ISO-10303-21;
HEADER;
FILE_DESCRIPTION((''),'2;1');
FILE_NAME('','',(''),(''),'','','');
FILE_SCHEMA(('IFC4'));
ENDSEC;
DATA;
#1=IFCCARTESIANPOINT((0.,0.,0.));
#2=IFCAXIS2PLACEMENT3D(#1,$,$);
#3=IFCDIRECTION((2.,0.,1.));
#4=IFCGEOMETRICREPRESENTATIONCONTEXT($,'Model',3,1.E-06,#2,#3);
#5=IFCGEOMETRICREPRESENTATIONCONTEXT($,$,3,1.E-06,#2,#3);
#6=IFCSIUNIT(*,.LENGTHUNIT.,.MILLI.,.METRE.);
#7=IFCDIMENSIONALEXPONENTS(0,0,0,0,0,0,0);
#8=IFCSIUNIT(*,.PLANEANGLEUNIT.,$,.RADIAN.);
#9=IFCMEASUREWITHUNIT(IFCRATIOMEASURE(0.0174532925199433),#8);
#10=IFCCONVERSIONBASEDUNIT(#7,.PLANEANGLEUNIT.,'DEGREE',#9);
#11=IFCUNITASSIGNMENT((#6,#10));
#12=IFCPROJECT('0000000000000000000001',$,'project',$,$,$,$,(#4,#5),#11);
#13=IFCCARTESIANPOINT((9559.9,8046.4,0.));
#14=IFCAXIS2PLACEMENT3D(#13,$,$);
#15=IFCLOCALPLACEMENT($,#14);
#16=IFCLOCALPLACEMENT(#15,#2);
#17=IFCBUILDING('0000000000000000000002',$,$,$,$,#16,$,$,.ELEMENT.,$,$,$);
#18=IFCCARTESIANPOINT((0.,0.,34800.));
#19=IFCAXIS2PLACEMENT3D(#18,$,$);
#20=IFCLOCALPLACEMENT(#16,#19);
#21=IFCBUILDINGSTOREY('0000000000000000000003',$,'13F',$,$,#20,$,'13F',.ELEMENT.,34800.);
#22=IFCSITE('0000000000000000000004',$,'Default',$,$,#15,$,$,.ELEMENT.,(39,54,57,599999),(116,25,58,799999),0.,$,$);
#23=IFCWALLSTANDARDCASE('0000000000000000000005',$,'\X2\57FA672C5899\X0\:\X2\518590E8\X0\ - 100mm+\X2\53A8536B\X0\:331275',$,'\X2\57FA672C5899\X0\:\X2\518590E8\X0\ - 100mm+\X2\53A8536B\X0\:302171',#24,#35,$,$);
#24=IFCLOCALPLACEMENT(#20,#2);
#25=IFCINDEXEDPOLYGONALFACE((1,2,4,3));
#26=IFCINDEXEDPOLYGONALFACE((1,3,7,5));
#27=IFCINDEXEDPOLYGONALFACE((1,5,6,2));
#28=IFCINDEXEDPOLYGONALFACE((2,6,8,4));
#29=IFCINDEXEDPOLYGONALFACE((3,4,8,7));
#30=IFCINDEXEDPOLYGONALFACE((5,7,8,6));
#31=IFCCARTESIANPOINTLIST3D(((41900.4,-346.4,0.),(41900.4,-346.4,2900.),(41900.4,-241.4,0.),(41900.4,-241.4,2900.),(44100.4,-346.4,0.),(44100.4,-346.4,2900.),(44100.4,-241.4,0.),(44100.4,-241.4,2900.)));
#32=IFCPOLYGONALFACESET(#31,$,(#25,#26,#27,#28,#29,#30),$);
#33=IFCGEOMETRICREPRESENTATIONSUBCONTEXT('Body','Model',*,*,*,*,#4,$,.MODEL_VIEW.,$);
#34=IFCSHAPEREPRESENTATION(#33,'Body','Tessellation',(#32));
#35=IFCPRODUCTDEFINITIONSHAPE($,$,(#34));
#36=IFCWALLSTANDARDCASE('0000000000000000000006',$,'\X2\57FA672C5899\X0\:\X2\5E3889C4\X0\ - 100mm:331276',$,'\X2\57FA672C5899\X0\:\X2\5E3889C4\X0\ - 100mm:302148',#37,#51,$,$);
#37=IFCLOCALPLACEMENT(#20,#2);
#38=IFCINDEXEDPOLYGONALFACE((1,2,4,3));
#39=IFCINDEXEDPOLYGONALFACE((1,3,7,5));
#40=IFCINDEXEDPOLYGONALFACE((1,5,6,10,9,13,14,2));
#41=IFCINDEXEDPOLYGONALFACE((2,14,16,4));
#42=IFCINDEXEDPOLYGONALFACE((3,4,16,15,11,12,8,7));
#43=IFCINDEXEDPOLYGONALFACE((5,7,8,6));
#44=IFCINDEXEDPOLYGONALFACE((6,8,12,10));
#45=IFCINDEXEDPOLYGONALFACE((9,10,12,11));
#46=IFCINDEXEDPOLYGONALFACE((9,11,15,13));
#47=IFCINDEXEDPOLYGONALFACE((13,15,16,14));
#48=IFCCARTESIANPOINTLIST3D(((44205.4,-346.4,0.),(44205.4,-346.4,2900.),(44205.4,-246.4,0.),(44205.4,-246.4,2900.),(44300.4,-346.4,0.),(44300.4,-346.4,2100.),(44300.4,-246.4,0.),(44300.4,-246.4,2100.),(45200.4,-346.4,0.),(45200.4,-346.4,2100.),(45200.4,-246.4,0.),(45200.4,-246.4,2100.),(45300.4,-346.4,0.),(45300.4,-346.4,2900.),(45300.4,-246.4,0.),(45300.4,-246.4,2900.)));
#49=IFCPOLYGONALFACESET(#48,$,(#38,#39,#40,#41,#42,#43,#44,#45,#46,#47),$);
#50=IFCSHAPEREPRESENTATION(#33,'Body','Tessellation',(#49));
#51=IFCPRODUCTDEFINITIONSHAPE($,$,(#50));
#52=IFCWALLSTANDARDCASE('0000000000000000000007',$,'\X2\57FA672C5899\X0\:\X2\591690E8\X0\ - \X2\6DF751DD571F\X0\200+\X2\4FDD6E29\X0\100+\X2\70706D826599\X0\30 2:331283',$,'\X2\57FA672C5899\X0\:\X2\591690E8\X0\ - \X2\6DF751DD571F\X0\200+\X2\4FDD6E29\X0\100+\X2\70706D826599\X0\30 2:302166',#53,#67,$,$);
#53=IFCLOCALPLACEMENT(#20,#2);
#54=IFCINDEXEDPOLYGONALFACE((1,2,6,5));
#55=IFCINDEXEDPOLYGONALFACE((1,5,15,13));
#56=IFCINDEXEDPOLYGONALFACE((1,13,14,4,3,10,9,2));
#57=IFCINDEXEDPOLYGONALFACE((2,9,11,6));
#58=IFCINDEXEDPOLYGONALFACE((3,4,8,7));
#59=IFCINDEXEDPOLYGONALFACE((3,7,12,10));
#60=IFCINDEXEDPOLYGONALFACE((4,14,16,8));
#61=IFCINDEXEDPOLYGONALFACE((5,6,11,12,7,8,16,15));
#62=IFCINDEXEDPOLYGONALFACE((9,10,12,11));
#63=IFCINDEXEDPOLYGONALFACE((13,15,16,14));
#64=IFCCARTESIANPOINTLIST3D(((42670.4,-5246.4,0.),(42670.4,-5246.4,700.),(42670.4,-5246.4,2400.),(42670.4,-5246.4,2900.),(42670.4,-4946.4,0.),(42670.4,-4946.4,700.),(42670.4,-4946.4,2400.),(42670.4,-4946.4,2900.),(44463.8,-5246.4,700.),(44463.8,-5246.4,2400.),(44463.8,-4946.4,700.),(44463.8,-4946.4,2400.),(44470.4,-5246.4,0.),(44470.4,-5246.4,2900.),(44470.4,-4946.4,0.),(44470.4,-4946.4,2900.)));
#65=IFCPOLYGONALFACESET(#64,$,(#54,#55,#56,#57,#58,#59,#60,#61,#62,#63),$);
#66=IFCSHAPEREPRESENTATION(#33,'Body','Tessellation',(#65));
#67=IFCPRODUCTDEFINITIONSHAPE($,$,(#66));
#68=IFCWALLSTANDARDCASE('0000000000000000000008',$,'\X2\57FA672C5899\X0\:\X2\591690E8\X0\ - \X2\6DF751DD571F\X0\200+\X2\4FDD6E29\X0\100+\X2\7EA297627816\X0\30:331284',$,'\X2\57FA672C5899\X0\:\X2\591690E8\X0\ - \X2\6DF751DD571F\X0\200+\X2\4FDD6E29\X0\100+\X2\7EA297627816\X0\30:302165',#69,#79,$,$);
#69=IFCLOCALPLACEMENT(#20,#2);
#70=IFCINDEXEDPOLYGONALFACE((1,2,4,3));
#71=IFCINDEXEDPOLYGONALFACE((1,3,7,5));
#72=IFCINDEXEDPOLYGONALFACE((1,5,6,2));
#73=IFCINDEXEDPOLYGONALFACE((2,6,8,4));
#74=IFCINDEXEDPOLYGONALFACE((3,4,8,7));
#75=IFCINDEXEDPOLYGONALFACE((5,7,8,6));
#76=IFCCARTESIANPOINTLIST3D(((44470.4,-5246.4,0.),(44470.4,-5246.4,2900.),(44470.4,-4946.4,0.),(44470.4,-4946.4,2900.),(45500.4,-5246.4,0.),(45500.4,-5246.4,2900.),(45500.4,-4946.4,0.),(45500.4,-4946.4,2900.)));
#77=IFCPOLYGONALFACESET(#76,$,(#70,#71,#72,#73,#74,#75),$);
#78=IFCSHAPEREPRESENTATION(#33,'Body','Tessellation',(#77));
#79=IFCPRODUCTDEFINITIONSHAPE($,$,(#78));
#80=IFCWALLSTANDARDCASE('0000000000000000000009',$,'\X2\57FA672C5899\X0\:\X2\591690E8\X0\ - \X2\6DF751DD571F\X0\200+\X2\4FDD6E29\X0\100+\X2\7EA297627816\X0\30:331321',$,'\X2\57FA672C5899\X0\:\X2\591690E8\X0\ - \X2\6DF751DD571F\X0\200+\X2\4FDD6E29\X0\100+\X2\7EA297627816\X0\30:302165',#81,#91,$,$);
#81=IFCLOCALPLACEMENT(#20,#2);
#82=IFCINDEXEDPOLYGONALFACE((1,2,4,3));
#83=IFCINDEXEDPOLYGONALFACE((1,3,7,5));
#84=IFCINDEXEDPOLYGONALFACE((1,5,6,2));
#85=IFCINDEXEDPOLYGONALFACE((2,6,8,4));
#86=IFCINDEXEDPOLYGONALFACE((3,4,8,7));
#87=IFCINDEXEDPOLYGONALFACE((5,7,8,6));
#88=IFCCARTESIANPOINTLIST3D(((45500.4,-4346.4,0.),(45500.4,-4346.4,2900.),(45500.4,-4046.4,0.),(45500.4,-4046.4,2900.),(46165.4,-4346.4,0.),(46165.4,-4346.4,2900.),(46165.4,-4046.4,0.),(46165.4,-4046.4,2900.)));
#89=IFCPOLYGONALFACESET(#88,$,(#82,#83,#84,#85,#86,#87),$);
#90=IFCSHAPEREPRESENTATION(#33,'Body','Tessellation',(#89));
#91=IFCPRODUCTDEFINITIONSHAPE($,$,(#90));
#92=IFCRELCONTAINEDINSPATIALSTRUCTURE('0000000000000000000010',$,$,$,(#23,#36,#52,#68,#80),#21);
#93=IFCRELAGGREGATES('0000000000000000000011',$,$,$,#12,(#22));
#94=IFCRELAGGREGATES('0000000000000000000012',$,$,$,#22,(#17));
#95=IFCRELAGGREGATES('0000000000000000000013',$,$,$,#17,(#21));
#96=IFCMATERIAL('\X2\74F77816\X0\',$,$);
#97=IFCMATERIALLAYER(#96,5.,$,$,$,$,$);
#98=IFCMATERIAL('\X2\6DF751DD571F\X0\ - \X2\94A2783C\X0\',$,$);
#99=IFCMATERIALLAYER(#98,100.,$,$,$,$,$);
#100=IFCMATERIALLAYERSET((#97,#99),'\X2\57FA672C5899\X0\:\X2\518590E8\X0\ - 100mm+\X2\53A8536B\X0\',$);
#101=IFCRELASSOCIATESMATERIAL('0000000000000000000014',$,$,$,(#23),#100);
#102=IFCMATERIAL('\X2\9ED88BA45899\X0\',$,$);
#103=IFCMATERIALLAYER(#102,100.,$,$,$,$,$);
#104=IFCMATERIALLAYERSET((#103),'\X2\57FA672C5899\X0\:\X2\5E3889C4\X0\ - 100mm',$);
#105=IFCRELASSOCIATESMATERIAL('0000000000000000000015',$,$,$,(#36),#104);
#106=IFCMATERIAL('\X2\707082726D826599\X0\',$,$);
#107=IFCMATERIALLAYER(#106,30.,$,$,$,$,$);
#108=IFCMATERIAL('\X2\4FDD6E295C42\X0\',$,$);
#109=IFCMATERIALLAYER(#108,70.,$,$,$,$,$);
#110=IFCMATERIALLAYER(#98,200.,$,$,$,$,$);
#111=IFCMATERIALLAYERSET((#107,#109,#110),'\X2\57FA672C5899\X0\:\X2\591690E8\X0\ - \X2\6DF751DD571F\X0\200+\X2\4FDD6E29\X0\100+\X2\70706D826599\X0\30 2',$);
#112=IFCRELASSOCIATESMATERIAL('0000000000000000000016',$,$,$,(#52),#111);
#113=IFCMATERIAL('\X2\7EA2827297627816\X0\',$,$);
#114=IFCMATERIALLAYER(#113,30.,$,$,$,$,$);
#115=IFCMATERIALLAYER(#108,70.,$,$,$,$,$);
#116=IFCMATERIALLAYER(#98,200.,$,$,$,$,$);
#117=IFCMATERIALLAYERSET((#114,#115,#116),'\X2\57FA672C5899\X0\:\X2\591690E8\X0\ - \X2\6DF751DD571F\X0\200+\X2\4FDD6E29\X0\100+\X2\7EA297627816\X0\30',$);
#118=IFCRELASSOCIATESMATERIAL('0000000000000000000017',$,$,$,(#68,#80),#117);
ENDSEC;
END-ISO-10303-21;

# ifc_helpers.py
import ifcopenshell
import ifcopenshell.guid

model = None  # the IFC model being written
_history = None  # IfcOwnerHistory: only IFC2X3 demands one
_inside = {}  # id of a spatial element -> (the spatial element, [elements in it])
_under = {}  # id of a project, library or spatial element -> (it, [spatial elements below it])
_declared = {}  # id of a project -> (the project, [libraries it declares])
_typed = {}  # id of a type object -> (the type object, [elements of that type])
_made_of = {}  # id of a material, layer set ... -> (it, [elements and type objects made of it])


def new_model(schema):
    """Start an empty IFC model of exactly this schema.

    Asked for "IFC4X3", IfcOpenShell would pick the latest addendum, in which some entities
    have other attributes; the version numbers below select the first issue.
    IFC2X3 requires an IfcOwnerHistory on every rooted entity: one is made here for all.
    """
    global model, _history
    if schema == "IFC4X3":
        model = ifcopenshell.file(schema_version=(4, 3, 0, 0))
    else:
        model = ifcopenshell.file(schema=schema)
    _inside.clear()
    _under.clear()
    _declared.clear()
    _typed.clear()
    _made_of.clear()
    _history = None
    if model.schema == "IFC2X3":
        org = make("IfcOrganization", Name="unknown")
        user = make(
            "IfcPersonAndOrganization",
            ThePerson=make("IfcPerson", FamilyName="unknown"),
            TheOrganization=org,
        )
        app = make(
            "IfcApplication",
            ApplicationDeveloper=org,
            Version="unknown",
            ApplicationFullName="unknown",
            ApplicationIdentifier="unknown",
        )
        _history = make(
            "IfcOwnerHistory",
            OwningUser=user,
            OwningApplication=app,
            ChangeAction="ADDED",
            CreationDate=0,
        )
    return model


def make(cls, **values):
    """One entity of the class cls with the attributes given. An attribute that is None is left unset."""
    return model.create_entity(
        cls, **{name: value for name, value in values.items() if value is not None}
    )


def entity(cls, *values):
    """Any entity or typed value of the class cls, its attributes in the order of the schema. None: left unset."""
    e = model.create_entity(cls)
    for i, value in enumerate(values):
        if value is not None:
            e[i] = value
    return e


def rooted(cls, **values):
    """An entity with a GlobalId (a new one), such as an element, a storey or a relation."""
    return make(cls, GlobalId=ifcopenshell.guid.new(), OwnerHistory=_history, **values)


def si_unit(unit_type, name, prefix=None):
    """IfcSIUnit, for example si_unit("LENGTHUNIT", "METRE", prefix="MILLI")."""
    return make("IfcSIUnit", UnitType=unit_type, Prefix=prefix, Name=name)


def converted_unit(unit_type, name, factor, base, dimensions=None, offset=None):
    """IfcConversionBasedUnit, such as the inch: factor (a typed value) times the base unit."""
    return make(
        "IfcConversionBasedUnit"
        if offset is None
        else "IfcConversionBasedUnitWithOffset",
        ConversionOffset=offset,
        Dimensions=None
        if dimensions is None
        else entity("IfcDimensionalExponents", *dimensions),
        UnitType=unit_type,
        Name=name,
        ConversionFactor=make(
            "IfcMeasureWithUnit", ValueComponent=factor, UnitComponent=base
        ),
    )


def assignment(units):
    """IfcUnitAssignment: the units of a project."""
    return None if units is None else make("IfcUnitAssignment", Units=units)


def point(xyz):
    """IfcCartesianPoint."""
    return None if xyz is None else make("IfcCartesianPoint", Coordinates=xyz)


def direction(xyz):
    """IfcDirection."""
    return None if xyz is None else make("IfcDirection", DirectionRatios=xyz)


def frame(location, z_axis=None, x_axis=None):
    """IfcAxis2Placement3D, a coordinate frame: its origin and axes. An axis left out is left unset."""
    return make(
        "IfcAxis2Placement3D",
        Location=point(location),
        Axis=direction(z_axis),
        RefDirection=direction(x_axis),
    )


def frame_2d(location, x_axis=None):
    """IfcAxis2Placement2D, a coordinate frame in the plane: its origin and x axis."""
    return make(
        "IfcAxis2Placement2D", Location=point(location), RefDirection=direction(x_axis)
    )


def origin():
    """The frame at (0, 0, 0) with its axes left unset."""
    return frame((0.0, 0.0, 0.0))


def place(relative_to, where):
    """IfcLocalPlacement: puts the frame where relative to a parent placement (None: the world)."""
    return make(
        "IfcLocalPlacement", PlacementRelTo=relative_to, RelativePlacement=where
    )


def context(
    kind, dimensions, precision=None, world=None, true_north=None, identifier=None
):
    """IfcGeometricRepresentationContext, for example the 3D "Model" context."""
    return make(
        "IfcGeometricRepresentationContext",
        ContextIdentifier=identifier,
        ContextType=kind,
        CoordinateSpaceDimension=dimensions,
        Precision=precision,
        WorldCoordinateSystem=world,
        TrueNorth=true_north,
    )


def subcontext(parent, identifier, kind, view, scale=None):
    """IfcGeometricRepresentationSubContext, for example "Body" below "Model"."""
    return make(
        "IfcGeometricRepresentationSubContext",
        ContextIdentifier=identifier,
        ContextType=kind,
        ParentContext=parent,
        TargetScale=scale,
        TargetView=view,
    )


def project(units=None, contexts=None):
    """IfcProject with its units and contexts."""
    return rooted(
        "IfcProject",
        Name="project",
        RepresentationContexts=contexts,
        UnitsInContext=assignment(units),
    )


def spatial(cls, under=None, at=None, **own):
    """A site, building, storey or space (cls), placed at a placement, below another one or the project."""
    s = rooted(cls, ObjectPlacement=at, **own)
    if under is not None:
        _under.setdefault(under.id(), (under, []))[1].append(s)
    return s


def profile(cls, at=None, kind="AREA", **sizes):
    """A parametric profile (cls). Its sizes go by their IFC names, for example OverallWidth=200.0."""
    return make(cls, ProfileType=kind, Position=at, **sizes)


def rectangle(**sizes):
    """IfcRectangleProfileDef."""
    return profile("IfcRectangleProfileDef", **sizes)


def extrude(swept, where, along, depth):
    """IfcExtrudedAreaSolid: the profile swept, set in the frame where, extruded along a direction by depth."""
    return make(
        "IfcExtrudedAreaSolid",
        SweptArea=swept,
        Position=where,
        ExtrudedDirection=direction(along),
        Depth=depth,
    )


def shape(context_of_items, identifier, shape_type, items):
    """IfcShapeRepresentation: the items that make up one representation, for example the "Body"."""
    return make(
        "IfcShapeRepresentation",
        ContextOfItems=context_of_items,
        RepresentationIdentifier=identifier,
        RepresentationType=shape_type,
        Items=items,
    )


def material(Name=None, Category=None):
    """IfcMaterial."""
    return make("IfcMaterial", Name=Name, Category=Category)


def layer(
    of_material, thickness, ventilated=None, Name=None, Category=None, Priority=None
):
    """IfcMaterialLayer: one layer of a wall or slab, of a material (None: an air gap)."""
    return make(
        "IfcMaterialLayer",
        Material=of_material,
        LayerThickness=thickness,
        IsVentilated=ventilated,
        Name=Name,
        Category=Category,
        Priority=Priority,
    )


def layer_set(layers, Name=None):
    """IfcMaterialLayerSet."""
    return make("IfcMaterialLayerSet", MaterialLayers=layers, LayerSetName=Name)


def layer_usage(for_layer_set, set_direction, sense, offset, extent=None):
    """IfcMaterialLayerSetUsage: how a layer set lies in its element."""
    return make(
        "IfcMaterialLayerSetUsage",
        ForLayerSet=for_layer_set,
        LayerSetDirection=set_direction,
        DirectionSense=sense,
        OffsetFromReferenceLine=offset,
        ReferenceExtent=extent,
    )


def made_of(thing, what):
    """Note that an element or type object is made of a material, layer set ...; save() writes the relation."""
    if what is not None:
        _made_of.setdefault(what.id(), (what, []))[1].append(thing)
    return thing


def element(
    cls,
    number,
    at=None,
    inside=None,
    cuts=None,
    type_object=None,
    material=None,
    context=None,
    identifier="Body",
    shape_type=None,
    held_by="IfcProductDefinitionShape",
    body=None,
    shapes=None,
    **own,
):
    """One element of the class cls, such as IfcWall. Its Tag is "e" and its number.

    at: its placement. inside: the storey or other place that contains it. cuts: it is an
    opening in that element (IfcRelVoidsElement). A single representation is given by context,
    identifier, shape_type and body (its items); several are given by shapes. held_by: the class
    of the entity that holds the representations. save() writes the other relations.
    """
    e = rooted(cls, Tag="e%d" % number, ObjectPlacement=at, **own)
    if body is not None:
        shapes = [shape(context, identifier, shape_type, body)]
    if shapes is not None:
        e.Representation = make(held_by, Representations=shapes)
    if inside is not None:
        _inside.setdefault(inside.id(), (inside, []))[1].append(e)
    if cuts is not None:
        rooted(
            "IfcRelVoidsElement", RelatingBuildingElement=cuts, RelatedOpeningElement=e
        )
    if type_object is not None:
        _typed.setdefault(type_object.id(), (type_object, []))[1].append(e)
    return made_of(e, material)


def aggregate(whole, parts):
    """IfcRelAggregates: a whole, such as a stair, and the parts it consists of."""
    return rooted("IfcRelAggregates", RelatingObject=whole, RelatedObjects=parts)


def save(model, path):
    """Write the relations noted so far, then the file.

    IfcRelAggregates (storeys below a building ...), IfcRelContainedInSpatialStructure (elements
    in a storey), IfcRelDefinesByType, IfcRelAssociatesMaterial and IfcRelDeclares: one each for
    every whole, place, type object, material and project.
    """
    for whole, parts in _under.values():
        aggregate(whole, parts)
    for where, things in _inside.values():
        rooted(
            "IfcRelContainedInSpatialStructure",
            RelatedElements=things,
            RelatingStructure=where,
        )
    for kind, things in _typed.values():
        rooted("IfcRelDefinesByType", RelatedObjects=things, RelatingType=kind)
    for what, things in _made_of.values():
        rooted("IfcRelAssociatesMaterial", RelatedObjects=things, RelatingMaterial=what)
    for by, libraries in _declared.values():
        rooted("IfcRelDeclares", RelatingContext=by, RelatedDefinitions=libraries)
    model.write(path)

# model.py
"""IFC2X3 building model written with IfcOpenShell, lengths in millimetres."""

from ifc_helpers import new_model, entity, si_unit, converted_unit, direction, frame, frame_2d, origin, place, context, subcontext, project, spatial, rectangle, extrude, material, layer, layer_set, layer_usage, element, save


model = new_model("IFC2X3")

# Units and contexts
model_context = context("Model", 3, precision=1e-06, world=origin(), true_north=direction((2.0, 0.0, 1.0)))
context_of_model = context(None, 3, precision=1e-06, world=origin(), true_north=direction((2.0, 0.0, 1.0)))
body_context = subcontext(model_context, "Body", "Model", "MODEL_VIEW")
ifc_project = project(units=[si_unit("LENGTHUNIT", "METRE", prefix="MILLI"), converted_unit("PLANEANGLEUNIT", "DEGREE", entity("IfcRatioMeasure", 0.0174532925199433), si_unit("PLANEANGLEUNIT", "RADIAN"), dimensions=[0, 0, 0, 0, 0, 0, 0])], contexts=[model_context, context_of_model])

# Site, building, storey
site_placement = place(None, frame((9559.9, 8046.4, 0.0)))
site = spatial("IfcSite", under=ifc_project, at=site_placement, Name="Default", CompositionType="ELEMENT", RefLatitude=(39, 54, 57, 599999), RefLongitude=(116, 25, 58, 799999), RefElevation=0.0)
building_placement = place(site_placement, origin())
building = spatial("IfcBuilding", under=site, at=building_placement, CompositionType="ELEMENT")
storey_placement = place(building_placement, frame((0.0, 0.0, 34800.0)))
storey = spatial("IfcBuildingStorey", under=building, at=storey_placement, Name="13F", LongName="13F", CompositionType="ELEMENT", Elevation=34800.0)

# Shared definitions
ifc_material_1 = material(Name="混凝土 - 钢砼")
ifc_material_2 = material(Name="红色面砖")
ifc_layer_1 = layer(ifc_material_2, 30.0)
ifc_material_3 = material(Name="保温层")
ifc_layer_2 = layer(ifc_material_3, 70.0)
ifc_layer_3 = layer(ifc_material_1, 200.0)
ifc_layer_set_1 = layer_set([ifc_layer_1, ifc_layer_2, ifc_layer_3], Name="基本墙:外部 - 混凝土200+保温100+红面砖30")

# Shared definitions
ifc_material_4 = material(Name="默认墙")
ifc_layer_4 = layer(ifc_material_4, 100.0)
ifc_layer_set_2 = layer_set([ifc_layer_4], Name="基本墙:常规 - 100mm")

# Shared definitions
ifc_material_5 = material(Name="瓷砖")
ifc_layer_5 = layer(ifc_material_5, 5.0)
ifc_layer_6 = layer(ifc_material_1, 100.0)
ifc_layer_set_3 = layer_set([ifc_layer_5, ifc_layer_6], Name="基本墙:内部 - 100mm+厨卫")

# Shared definitions
ifc_material_6 = material(Name="灰色涂料")
ifc_layer_7 = layer(ifc_material_6, 30.0)
ifc_layer_8 = layer(ifc_material_3, 70.0)
ifc_layer_9 = layer(ifc_material_1, 200.0)
ifc_layer_set_4 = layer_set([ifc_layer_7, ifc_layer_8, ifc_layer_9], Name="基本墙:外部 - 混凝土200+保温100+灰涂料30 2")

# Wall
ifc_layer_usage_1 = layer_usage(ifc_layer_set_3, "AXIS2", "NEGATIVE", 52.5)
wall_1_placement = place(storey_placement, frame((41900.4, -293.9, 0.0)))
element("IfcWallStandardCase", 1, at=wall_1_placement, inside=storey, material=ifc_layer_usage_1, Name="基本墙:内部 - 100mm+厨卫:331275", ObjectType="基本墙:内部 - 100mm+厨卫:302171", context=body_context, shape_type="SweptSolid", body=[
    extrude(rectangle(XDim=2200.0, YDim=105.0, at=frame_2d((1100.0, 0.0), x_axis=(-1.0, 0.0))), origin(), (0.0, 0.0, 1.0), 2900.0),
])

# Walls, openings
ifc_layer_usage_2 = layer_usage(ifc_layer_set_2, "AXIS2", "NEGATIVE", 50.0)
wall_2_placement = place(storey_placement, frame((44205.4, -296.4, 0.0)))
wall_2 = element("IfcWallStandardCase", 2, at=wall_2_placement, inside=storey, material=ifc_layer_usage_2, Name="基本墙:常规 - 100mm:331276", ObjectType="基本墙:常规 - 100mm:302148", context=body_context, shape_type="SweptSolid", body=[
    extrude(rectangle(XDim=1095.0, YDim=100.0, at=frame_2d((547.5, 0.0), x_axis=(-1.0, 0.0))), origin(), (0.0, 0.0, 1.0), 2900.0),
])
opening_1_placement = place(wall_2_placement, frame((995.0, 50.0, 0.0)))
element("IfcOpeningElement", 3, at=opening_1_placement, cuts=wall_2, ObjectType="Opening", context=body_context, shape_type="SweptSolid", body=[
    extrude(rectangle(XDim=2100.0, YDim=900.0, at=frame_2d((1050.0, 450.0), x_axis=(1.0, 0.0))), frame((0.0, 0.0, 0.0), z_axis=(0.0, -1.0, 0.0), x_axis=(0.0, 0.0, 1.0)), (0.0, 0.0, 1.0), 100.0),
])
ifc_layer_usage_3 = layer_usage(ifc_layer_set_4, "AXIS2", "POSITIVE", -150.0)
wall_3_placement = place(storey_placement, frame((42670.4, -5096.4, 0.0)))
wall_3 = element("IfcWallStandardCase", 4, at=wall_3_placement, inside=storey, material=ifc_layer_usage_3, Name="基本墙:外部 - 混凝土200+保温100+灰涂料30 2:331283", ObjectType="基本墙:外部 - 混凝土200+保温100+灰涂料30 2:302166", context=body_context, shape_type="SweptSolid", body=[
    extrude(rectangle(XDim=1800.0, YDim=300.0, at=frame_2d((900.0, 0.0), x_axis=(-1.0, 0.0))), origin(), (0.0, 0.0, 1.0), 2900.0),
])
opening_2_placement = place(wall_3_placement, frame((1793.4, 150.0, 700.0)))
element("IfcOpeningElement", 5, at=opening_2_placement, cuts=wall_3, ObjectType="Opening", context=body_context, shape_type="SweptSolid", body=[
    extrude(rectangle(XDim=1700.0, YDim=1800.0, at=frame_2d((850.0, 900.0), x_axis=(1.0, 0.0))), frame((0.0, 0.0, 0.0), z_axis=(0.0, -1.0, 0.0), x_axis=(0.0, 0.0, 1.0)), (0.0, 0.0, 1.0), 300.0),
])

# Walls
ifc_layer_usage_4 = layer_usage(ifc_layer_set_1, "AXIS2", "POSITIVE", -150.0)
wall_4_placement = place(storey_placement, frame((44470.4, -5096.4, 0.0)))
element("IfcWallStandardCase", 6, at=wall_4_placement, inside=storey, material=ifc_layer_usage_4, Name="基本墙:外部 - 混凝土200+保温100+红面砖30:331284", ObjectType="基本墙:外部 - 混凝土200+保温100+红面砖30:302165", context=body_context, shape_type="SweptSolid", body=[
    extrude(rectangle(XDim=1030.0, YDim=300.0, at=frame_2d((515.0, 0.0), x_axis=(-1.0, 0.0))), origin(), (0.0, 0.0, 1.0), 2900.0),
])
ifc_layer_usage_5 = layer_usage(ifc_layer_set_1, "AXIS2", "POSITIVE", -150.0)
wall_5_placement = place(storey_placement, frame((45500.4, -4196.4, 0.0)))
element("IfcWallStandardCase", 7, at=wall_5_placement, inside=storey, material=ifc_layer_usage_5, Name="基本墙:外部 - 混凝土200+保温100+红面砖30:331321", ObjectType="基本墙:外部 - 混凝土200+保温100+红面砖30:302165", context=body_context, shape_type="SweptSolid", body=[
    extrude(rectangle(XDim=665.0, YDim=300.0, at=frame_2d((332.5, 0.0), x_axis=(-1.0, 0.0))), origin(), (0.0, 0.0, 1.0), 2900.0),
])

save(model, "model.ifc")
